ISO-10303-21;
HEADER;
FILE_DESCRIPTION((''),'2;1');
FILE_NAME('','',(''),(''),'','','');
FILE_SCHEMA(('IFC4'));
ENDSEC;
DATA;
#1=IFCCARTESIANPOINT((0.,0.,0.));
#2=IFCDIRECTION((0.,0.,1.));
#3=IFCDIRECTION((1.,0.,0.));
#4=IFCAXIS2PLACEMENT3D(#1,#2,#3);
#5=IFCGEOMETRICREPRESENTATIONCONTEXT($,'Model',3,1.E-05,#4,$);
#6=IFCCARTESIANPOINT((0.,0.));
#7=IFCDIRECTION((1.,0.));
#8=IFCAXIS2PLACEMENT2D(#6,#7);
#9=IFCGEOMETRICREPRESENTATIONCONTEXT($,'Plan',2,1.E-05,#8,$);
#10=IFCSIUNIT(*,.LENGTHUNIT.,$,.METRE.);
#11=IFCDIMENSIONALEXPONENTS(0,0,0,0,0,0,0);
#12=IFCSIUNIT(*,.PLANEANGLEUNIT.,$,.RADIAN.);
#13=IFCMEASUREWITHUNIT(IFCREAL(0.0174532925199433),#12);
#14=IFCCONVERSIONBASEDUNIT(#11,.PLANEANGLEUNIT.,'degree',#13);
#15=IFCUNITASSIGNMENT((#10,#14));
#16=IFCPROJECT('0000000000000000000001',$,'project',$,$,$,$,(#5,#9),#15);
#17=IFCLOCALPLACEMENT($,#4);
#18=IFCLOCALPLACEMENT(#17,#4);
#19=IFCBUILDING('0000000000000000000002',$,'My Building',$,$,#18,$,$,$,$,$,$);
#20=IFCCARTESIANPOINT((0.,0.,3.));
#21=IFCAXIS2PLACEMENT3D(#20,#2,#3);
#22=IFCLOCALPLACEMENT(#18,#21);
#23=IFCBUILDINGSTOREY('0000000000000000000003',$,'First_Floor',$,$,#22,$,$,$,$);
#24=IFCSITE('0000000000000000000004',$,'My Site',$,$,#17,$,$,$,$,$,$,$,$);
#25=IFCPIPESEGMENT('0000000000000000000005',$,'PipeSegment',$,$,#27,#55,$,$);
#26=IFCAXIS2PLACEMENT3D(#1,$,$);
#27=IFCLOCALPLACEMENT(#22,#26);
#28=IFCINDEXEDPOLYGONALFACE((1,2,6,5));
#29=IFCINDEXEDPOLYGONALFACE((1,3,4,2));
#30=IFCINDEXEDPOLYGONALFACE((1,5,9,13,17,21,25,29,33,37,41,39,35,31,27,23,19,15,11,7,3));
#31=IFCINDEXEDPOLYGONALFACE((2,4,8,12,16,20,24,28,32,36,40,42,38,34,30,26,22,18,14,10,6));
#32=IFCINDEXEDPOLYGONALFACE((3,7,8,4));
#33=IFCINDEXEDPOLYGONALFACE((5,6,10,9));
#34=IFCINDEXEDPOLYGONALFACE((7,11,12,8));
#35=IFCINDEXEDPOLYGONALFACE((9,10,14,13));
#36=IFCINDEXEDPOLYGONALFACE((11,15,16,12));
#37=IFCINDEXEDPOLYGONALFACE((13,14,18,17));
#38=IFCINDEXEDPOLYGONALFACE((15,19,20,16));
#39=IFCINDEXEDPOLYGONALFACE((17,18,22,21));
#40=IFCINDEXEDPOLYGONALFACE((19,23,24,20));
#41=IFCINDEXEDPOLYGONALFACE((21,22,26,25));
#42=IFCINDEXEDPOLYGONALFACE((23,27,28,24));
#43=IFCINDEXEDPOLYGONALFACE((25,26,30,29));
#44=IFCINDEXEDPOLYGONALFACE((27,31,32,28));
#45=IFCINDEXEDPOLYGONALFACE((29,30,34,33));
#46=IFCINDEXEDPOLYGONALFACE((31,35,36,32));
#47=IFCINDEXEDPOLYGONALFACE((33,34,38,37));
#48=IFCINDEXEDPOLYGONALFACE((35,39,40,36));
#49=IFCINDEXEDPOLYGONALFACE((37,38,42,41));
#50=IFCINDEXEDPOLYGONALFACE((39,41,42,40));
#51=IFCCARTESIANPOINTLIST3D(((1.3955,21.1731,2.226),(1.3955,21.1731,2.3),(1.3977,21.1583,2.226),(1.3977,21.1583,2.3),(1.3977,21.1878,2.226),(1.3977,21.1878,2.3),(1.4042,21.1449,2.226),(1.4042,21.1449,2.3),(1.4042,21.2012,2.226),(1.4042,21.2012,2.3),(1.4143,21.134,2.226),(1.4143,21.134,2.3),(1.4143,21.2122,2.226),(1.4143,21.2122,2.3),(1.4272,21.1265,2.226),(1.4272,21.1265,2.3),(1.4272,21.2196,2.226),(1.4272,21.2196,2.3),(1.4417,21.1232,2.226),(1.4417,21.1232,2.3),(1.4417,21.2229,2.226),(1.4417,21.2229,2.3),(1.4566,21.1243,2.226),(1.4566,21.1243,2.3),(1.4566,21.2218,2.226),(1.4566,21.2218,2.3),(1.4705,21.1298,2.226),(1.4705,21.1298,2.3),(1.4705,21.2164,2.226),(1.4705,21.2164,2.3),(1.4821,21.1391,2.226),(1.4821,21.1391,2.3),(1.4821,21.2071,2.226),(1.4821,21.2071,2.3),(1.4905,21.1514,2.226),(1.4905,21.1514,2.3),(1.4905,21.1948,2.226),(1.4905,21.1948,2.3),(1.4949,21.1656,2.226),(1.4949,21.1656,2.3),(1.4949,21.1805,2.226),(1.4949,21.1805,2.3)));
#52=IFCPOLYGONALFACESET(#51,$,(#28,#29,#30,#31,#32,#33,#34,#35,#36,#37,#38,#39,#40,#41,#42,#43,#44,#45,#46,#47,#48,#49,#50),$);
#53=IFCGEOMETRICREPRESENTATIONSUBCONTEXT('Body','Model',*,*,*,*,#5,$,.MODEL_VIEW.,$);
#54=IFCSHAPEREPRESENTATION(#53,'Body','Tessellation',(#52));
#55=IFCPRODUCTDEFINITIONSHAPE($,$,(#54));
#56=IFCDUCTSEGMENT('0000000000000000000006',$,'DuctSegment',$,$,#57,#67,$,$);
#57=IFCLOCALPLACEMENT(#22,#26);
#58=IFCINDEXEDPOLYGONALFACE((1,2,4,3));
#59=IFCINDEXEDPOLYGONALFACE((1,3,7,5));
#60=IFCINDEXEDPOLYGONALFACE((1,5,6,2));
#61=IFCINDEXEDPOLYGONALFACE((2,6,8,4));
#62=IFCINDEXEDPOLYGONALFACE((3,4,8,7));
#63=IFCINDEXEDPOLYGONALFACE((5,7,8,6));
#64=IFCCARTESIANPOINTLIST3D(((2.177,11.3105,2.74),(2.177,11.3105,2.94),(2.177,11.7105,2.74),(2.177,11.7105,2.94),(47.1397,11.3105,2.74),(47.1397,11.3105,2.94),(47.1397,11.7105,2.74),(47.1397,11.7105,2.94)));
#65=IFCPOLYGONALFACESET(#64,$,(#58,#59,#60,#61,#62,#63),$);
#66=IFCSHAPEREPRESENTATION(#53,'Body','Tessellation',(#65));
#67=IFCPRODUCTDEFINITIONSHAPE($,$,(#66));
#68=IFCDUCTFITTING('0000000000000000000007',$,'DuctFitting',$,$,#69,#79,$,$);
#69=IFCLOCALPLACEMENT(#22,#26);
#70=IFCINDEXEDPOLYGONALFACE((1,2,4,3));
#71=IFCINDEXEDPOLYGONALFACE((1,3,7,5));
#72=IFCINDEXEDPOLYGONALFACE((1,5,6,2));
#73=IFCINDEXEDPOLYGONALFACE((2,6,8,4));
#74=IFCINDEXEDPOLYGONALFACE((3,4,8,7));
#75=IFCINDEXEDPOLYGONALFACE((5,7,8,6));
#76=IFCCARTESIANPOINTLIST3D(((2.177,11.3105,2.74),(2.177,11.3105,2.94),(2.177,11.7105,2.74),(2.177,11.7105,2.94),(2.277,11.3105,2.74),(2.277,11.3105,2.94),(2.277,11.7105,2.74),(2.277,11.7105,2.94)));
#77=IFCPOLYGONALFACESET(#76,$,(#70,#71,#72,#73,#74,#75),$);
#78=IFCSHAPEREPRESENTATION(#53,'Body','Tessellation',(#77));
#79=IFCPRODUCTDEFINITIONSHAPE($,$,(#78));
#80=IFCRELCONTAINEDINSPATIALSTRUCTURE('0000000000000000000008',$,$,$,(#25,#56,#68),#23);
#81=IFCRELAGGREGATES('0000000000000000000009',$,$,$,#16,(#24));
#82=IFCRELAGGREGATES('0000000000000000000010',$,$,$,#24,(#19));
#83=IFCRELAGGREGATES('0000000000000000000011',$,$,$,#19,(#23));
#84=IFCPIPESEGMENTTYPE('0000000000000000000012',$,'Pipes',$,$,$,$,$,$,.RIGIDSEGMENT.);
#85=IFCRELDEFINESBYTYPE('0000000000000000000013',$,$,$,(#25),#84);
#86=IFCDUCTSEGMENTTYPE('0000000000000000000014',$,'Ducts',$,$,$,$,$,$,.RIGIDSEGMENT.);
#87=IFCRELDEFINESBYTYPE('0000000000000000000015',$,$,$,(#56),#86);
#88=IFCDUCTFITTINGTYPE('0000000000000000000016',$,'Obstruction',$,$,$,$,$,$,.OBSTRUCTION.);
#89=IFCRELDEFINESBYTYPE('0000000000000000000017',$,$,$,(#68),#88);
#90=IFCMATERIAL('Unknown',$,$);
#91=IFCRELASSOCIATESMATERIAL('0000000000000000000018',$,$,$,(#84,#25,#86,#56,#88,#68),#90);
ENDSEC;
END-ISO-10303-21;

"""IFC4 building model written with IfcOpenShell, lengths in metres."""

from ifc_helpers import new_model, entity, si_unit, converted_unit, frame, origin_with_axes, origin_2d_with_axis, place, context, subcontext, project, spatial, rectangle, circle, extrude, material, material_profile, profile_set, profile_usage, type_object, element, save


model = new_model("IFC4")

# Units and contexts
model_context = context("Model", 3, precision=1e-05, world=origin_with_axes())
plan_context = context("Plan", 2, precision=1e-05, world=origin_2d_with_axis())
body_context = subcontext(model_context, "Body", "Model", "MODEL_VIEW")
ifc_project = project(units=[si_unit("LENGTHUNIT", "METRE"), converted_unit("PLANEANGLEUNIT", "degree", entity("IfcReal", 0.0174532925199433), si_unit("PLANEANGLEUNIT", "RADIAN"), dimensions=[0, 0, 0, 0, 0, 0, 0])], contexts=[model_context, plan_context])

# Site, building, storey
site_placement = place(None, origin_with_axes())
site = spatial("IfcSite", under=ifc_project, at=site_placement, Name="My Site")
building_placement = place(site_placement, origin_with_axes())
building = spatial("IfcBuilding", under=site, at=building_placement, Name="My Building")
storey_placement = place(building_placement, frame((0.0, 0.0, 3.0), z_axis=(0.0, 0.0, 1.0), x_axis=(1.0, 0.0, 0.0)))
storey = spatial("IfcBuildingStorey", under=building, at=storey_placement, Name="First_Floor")

# Shared definitions
ifc_material = material(Name="Unknown")

# Pipe segment
ifc_material_profile_1 = material_profile(ifc_material, circle(Radius=0.05))
ifc_profile_set_1 = profile_set([ifc_material_profile_1])
pipe_segment_type = type_object("IfcPipeSegmentType", Name="Pipes", PredefinedType="RIGIDSEGMENT", material=ifc_profile_set_1)
ifc_profile_usage_1 = profile_usage(ifc_profile_set_1, cardinal=5)
pipe_segment_1_placement = place(storey_placement, frame((1.4455, 21.1731, 2.3), z_axis=(0.0, 0.0, -1.0), x_axis=(-1.0, 0.0, 0.0)))
element("IfcPipeSegment", 1, at=pipe_segment_1_placement, inside=storey, type_object=pipe_segment_type, material=ifc_profile_usage_1, Name="PipeSegment", context=body_context, shape_type="SweptSolid", body=[
    extrude(circle(Radius=0.05), origin_with_axes(), (0.0, 0.0, 1.0), 0.074),
])

# Duct segment
ifc_material_profile_2 = material_profile(ifc_material, rectangle(XDim=0.4, YDim=0.2))
ifc_profile_set_2 = profile_set([ifc_material_profile_2])
ifc_profile_usage_2 = profile_usage(ifc_profile_set_2, cardinal=5)
duct_segment_type = type_object("IfcDuctSegmentType", Name="Ducts", PredefinedType="RIGIDSEGMENT", material=ifc_profile_set_2)
duct_segment_placement = place(storey_placement, frame((2.177, 11.5105, 2.84), z_axis=(1.0, 0.0, 0.0), x_axis=(0.0, 1.0, 0.0)))
element("IfcDuctSegment", 2, at=duct_segment_placement, inside=storey, type_object=duct_segment_type, material=ifc_profile_usage_2, Name="DuctSegment", context=body_context, shape_type="SweptSolid", body=[
    extrude(rectangle(XDim=0.4, YDim=0.2), origin_with_axes(), (0.0, 0.0, 1.0), 44.9627),
])

# Duct fitting
ifc_material_profile_3 = material_profile(ifc_material, rectangle(XDim=0.4, YDim=0.2))
ifc_profile_set_3 = profile_set([ifc_material_profile_3])
ifc_profile_usage_3 = profile_usage(ifc_profile_set_3, cardinal=5)
duct_fitting_type = type_object("IfcDuctFittingType", Name="Obstruction", PredefinedType="OBSTRUCTION", material=ifc_profile_set_3)
duct_fitting_placement = place(storey_placement, frame((2.177, 11.5105, 2.84), z_axis=(1.0, 0.0, 0.0), x_axis=(0.0, 1.0, 0.0)))
element("IfcDuctFitting", 3, at=duct_fitting_placement, inside=storey, type_object=duct_fitting_type, material=ifc_profile_usage_3, Name="DuctFitting", context=body_context, shape_type="SweptSolid", body=[
    extrude(rectangle(XDim=0.4, YDim=0.2), origin_with_axes(), (0.0, 0.0, 1.0), 0.1),
])

save(model, "model.ifc")
